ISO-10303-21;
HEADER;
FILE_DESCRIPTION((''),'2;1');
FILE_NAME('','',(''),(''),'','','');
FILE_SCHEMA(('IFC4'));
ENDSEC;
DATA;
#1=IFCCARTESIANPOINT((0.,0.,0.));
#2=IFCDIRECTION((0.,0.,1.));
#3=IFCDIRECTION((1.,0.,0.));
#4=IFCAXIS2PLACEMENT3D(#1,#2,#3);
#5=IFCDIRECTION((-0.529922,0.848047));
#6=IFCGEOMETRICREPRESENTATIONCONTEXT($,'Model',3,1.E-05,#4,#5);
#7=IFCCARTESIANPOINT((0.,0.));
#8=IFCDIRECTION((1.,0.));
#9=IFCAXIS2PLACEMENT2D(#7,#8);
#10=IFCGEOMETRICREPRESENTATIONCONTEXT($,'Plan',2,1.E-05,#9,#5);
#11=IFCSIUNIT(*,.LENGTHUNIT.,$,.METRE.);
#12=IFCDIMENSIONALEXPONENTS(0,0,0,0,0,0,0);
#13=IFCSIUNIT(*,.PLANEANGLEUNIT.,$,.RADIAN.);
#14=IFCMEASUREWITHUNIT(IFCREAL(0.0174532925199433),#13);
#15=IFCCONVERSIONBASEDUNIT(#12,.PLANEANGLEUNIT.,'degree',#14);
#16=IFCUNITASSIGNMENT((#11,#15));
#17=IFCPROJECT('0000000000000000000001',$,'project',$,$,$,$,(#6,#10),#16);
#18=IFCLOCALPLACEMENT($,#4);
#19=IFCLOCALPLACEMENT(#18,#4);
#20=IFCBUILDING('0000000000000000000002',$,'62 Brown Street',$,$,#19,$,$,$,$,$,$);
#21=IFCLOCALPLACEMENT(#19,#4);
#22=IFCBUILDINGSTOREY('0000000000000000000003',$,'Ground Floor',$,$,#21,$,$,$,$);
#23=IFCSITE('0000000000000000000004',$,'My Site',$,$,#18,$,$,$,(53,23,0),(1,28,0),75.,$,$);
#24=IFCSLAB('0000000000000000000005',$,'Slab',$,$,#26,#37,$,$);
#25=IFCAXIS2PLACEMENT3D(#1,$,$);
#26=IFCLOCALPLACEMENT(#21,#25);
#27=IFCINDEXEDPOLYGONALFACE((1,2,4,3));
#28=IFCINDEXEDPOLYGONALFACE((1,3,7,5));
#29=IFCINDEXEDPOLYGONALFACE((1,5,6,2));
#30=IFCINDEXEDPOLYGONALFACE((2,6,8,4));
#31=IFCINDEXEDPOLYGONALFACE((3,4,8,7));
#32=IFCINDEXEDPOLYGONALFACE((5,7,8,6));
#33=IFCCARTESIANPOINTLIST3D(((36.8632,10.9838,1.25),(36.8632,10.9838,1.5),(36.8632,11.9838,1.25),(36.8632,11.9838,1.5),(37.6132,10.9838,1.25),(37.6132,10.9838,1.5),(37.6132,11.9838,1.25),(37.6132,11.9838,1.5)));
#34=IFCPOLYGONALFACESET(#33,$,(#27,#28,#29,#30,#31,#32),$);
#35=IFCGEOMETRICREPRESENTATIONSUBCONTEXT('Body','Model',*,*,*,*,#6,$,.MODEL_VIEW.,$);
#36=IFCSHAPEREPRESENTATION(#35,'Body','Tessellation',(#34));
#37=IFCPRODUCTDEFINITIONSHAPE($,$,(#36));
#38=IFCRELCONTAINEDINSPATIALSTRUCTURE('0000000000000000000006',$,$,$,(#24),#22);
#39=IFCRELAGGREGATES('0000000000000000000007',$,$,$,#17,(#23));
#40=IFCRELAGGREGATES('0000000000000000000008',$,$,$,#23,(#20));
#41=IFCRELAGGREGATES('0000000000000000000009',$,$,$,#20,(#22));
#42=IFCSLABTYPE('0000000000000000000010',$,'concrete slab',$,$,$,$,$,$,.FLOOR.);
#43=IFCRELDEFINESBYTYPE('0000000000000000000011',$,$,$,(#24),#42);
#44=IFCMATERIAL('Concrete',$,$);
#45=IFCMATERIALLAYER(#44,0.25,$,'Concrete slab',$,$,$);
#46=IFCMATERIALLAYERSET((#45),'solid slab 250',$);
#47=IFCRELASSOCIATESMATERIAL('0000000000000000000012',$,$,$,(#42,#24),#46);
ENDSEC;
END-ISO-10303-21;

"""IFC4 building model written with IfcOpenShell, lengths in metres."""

from ifc_helpers import new_model, entity, si_unit, converted_unit, direction, frame, origin_with_axes, origin_2d_with_axis, place, context, subcontext, project, spatial, line, indexed_curve, outline, extrude, material, layer, layer_set, layer_usage, type_object, element, save


model = new_model("IFC4")

# Units and contexts
model_context = context("Model", 3, precision=1e-05, world=origin_with_axes(), true_north=direction((-0.529922, 0.848047)))
plan_context = context("Plan", 2, precision=1e-05, world=origin_2d_with_axis(), true_north=direction((-0.529922, 0.848047)))
body_context_1 = subcontext(model_context, "Body", "Model", "MODEL_VIEW")
ifc_project = project(units=[si_unit("LENGTHUNIT", "METRE"), converted_unit("PLANEANGLEUNIT", "degree", entity("IfcReal", 0.0174532925199433), si_unit("PLANEANGLEUNIT", "RADIAN"), dimensions=[0, 0, 0, 0, 0, 0, 0])], contexts=[model_context, plan_context])

# Site, building, storey
site_placement = place(None, origin_with_axes())
site = spatial("IfcSite", under=ifc_project, at=site_placement, Name="My Site", RefLatitude=(53, 23, 0), RefLongitude=(1, 28, 0), RefElevation=75.0)
building_placement = place(site_placement, origin_with_axes())
building = spatial("IfcBuilding", under=site, at=building_placement, Name="62 Brown Street")
storey_placement = place(building_placement, origin_with_axes())
storey = spatial("IfcBuildingStorey", under=building, at=storey_placement, Name="Ground Floor")

# Slab
ifc_material_1 = material(Name="Concrete")
ifc_layer_1 = layer(ifc_material_1, 0.25, Name="Concrete slab")
ifc_layer_set_1 = layer_set([ifc_layer_1], Name="solid slab 250")
ifc_layer_usage_1 = layer_usage(ifc_layer_set_1, "AXIS3", "POSITIVE", 0.0)
slab_type = type_object("IfcSlabType", Name="concrete slab", PredefinedType="FLOOR", material=ifc_layer_set_1)
slab_placement = place(storey_placement, frame((36.8632, 10.9838, 1.25), z_axis=(0.0, 0.0, 1.0), x_axis=(1.0, 0.0, 0.0)))
element("IfcSlab", 1, at=slab_placement, inside=storey, type_object=slab_type, material=ifc_layer_usage_1, Name="Slab", context=body_context_1, shape_type="SweptSolid", body=[
    extrude(outline(indexed_curve([(0.0, 0.0), (0.75, 0.0), (0.75, 1.0), (0.0, 1.0)], segments=[line(4, 1), line(1, 2), line(2, 3), line(3, 4)], self_intersect=False)), None, (0.0, 0.0, 1.0), 0.25),
])

save(model, "model.ifc")
